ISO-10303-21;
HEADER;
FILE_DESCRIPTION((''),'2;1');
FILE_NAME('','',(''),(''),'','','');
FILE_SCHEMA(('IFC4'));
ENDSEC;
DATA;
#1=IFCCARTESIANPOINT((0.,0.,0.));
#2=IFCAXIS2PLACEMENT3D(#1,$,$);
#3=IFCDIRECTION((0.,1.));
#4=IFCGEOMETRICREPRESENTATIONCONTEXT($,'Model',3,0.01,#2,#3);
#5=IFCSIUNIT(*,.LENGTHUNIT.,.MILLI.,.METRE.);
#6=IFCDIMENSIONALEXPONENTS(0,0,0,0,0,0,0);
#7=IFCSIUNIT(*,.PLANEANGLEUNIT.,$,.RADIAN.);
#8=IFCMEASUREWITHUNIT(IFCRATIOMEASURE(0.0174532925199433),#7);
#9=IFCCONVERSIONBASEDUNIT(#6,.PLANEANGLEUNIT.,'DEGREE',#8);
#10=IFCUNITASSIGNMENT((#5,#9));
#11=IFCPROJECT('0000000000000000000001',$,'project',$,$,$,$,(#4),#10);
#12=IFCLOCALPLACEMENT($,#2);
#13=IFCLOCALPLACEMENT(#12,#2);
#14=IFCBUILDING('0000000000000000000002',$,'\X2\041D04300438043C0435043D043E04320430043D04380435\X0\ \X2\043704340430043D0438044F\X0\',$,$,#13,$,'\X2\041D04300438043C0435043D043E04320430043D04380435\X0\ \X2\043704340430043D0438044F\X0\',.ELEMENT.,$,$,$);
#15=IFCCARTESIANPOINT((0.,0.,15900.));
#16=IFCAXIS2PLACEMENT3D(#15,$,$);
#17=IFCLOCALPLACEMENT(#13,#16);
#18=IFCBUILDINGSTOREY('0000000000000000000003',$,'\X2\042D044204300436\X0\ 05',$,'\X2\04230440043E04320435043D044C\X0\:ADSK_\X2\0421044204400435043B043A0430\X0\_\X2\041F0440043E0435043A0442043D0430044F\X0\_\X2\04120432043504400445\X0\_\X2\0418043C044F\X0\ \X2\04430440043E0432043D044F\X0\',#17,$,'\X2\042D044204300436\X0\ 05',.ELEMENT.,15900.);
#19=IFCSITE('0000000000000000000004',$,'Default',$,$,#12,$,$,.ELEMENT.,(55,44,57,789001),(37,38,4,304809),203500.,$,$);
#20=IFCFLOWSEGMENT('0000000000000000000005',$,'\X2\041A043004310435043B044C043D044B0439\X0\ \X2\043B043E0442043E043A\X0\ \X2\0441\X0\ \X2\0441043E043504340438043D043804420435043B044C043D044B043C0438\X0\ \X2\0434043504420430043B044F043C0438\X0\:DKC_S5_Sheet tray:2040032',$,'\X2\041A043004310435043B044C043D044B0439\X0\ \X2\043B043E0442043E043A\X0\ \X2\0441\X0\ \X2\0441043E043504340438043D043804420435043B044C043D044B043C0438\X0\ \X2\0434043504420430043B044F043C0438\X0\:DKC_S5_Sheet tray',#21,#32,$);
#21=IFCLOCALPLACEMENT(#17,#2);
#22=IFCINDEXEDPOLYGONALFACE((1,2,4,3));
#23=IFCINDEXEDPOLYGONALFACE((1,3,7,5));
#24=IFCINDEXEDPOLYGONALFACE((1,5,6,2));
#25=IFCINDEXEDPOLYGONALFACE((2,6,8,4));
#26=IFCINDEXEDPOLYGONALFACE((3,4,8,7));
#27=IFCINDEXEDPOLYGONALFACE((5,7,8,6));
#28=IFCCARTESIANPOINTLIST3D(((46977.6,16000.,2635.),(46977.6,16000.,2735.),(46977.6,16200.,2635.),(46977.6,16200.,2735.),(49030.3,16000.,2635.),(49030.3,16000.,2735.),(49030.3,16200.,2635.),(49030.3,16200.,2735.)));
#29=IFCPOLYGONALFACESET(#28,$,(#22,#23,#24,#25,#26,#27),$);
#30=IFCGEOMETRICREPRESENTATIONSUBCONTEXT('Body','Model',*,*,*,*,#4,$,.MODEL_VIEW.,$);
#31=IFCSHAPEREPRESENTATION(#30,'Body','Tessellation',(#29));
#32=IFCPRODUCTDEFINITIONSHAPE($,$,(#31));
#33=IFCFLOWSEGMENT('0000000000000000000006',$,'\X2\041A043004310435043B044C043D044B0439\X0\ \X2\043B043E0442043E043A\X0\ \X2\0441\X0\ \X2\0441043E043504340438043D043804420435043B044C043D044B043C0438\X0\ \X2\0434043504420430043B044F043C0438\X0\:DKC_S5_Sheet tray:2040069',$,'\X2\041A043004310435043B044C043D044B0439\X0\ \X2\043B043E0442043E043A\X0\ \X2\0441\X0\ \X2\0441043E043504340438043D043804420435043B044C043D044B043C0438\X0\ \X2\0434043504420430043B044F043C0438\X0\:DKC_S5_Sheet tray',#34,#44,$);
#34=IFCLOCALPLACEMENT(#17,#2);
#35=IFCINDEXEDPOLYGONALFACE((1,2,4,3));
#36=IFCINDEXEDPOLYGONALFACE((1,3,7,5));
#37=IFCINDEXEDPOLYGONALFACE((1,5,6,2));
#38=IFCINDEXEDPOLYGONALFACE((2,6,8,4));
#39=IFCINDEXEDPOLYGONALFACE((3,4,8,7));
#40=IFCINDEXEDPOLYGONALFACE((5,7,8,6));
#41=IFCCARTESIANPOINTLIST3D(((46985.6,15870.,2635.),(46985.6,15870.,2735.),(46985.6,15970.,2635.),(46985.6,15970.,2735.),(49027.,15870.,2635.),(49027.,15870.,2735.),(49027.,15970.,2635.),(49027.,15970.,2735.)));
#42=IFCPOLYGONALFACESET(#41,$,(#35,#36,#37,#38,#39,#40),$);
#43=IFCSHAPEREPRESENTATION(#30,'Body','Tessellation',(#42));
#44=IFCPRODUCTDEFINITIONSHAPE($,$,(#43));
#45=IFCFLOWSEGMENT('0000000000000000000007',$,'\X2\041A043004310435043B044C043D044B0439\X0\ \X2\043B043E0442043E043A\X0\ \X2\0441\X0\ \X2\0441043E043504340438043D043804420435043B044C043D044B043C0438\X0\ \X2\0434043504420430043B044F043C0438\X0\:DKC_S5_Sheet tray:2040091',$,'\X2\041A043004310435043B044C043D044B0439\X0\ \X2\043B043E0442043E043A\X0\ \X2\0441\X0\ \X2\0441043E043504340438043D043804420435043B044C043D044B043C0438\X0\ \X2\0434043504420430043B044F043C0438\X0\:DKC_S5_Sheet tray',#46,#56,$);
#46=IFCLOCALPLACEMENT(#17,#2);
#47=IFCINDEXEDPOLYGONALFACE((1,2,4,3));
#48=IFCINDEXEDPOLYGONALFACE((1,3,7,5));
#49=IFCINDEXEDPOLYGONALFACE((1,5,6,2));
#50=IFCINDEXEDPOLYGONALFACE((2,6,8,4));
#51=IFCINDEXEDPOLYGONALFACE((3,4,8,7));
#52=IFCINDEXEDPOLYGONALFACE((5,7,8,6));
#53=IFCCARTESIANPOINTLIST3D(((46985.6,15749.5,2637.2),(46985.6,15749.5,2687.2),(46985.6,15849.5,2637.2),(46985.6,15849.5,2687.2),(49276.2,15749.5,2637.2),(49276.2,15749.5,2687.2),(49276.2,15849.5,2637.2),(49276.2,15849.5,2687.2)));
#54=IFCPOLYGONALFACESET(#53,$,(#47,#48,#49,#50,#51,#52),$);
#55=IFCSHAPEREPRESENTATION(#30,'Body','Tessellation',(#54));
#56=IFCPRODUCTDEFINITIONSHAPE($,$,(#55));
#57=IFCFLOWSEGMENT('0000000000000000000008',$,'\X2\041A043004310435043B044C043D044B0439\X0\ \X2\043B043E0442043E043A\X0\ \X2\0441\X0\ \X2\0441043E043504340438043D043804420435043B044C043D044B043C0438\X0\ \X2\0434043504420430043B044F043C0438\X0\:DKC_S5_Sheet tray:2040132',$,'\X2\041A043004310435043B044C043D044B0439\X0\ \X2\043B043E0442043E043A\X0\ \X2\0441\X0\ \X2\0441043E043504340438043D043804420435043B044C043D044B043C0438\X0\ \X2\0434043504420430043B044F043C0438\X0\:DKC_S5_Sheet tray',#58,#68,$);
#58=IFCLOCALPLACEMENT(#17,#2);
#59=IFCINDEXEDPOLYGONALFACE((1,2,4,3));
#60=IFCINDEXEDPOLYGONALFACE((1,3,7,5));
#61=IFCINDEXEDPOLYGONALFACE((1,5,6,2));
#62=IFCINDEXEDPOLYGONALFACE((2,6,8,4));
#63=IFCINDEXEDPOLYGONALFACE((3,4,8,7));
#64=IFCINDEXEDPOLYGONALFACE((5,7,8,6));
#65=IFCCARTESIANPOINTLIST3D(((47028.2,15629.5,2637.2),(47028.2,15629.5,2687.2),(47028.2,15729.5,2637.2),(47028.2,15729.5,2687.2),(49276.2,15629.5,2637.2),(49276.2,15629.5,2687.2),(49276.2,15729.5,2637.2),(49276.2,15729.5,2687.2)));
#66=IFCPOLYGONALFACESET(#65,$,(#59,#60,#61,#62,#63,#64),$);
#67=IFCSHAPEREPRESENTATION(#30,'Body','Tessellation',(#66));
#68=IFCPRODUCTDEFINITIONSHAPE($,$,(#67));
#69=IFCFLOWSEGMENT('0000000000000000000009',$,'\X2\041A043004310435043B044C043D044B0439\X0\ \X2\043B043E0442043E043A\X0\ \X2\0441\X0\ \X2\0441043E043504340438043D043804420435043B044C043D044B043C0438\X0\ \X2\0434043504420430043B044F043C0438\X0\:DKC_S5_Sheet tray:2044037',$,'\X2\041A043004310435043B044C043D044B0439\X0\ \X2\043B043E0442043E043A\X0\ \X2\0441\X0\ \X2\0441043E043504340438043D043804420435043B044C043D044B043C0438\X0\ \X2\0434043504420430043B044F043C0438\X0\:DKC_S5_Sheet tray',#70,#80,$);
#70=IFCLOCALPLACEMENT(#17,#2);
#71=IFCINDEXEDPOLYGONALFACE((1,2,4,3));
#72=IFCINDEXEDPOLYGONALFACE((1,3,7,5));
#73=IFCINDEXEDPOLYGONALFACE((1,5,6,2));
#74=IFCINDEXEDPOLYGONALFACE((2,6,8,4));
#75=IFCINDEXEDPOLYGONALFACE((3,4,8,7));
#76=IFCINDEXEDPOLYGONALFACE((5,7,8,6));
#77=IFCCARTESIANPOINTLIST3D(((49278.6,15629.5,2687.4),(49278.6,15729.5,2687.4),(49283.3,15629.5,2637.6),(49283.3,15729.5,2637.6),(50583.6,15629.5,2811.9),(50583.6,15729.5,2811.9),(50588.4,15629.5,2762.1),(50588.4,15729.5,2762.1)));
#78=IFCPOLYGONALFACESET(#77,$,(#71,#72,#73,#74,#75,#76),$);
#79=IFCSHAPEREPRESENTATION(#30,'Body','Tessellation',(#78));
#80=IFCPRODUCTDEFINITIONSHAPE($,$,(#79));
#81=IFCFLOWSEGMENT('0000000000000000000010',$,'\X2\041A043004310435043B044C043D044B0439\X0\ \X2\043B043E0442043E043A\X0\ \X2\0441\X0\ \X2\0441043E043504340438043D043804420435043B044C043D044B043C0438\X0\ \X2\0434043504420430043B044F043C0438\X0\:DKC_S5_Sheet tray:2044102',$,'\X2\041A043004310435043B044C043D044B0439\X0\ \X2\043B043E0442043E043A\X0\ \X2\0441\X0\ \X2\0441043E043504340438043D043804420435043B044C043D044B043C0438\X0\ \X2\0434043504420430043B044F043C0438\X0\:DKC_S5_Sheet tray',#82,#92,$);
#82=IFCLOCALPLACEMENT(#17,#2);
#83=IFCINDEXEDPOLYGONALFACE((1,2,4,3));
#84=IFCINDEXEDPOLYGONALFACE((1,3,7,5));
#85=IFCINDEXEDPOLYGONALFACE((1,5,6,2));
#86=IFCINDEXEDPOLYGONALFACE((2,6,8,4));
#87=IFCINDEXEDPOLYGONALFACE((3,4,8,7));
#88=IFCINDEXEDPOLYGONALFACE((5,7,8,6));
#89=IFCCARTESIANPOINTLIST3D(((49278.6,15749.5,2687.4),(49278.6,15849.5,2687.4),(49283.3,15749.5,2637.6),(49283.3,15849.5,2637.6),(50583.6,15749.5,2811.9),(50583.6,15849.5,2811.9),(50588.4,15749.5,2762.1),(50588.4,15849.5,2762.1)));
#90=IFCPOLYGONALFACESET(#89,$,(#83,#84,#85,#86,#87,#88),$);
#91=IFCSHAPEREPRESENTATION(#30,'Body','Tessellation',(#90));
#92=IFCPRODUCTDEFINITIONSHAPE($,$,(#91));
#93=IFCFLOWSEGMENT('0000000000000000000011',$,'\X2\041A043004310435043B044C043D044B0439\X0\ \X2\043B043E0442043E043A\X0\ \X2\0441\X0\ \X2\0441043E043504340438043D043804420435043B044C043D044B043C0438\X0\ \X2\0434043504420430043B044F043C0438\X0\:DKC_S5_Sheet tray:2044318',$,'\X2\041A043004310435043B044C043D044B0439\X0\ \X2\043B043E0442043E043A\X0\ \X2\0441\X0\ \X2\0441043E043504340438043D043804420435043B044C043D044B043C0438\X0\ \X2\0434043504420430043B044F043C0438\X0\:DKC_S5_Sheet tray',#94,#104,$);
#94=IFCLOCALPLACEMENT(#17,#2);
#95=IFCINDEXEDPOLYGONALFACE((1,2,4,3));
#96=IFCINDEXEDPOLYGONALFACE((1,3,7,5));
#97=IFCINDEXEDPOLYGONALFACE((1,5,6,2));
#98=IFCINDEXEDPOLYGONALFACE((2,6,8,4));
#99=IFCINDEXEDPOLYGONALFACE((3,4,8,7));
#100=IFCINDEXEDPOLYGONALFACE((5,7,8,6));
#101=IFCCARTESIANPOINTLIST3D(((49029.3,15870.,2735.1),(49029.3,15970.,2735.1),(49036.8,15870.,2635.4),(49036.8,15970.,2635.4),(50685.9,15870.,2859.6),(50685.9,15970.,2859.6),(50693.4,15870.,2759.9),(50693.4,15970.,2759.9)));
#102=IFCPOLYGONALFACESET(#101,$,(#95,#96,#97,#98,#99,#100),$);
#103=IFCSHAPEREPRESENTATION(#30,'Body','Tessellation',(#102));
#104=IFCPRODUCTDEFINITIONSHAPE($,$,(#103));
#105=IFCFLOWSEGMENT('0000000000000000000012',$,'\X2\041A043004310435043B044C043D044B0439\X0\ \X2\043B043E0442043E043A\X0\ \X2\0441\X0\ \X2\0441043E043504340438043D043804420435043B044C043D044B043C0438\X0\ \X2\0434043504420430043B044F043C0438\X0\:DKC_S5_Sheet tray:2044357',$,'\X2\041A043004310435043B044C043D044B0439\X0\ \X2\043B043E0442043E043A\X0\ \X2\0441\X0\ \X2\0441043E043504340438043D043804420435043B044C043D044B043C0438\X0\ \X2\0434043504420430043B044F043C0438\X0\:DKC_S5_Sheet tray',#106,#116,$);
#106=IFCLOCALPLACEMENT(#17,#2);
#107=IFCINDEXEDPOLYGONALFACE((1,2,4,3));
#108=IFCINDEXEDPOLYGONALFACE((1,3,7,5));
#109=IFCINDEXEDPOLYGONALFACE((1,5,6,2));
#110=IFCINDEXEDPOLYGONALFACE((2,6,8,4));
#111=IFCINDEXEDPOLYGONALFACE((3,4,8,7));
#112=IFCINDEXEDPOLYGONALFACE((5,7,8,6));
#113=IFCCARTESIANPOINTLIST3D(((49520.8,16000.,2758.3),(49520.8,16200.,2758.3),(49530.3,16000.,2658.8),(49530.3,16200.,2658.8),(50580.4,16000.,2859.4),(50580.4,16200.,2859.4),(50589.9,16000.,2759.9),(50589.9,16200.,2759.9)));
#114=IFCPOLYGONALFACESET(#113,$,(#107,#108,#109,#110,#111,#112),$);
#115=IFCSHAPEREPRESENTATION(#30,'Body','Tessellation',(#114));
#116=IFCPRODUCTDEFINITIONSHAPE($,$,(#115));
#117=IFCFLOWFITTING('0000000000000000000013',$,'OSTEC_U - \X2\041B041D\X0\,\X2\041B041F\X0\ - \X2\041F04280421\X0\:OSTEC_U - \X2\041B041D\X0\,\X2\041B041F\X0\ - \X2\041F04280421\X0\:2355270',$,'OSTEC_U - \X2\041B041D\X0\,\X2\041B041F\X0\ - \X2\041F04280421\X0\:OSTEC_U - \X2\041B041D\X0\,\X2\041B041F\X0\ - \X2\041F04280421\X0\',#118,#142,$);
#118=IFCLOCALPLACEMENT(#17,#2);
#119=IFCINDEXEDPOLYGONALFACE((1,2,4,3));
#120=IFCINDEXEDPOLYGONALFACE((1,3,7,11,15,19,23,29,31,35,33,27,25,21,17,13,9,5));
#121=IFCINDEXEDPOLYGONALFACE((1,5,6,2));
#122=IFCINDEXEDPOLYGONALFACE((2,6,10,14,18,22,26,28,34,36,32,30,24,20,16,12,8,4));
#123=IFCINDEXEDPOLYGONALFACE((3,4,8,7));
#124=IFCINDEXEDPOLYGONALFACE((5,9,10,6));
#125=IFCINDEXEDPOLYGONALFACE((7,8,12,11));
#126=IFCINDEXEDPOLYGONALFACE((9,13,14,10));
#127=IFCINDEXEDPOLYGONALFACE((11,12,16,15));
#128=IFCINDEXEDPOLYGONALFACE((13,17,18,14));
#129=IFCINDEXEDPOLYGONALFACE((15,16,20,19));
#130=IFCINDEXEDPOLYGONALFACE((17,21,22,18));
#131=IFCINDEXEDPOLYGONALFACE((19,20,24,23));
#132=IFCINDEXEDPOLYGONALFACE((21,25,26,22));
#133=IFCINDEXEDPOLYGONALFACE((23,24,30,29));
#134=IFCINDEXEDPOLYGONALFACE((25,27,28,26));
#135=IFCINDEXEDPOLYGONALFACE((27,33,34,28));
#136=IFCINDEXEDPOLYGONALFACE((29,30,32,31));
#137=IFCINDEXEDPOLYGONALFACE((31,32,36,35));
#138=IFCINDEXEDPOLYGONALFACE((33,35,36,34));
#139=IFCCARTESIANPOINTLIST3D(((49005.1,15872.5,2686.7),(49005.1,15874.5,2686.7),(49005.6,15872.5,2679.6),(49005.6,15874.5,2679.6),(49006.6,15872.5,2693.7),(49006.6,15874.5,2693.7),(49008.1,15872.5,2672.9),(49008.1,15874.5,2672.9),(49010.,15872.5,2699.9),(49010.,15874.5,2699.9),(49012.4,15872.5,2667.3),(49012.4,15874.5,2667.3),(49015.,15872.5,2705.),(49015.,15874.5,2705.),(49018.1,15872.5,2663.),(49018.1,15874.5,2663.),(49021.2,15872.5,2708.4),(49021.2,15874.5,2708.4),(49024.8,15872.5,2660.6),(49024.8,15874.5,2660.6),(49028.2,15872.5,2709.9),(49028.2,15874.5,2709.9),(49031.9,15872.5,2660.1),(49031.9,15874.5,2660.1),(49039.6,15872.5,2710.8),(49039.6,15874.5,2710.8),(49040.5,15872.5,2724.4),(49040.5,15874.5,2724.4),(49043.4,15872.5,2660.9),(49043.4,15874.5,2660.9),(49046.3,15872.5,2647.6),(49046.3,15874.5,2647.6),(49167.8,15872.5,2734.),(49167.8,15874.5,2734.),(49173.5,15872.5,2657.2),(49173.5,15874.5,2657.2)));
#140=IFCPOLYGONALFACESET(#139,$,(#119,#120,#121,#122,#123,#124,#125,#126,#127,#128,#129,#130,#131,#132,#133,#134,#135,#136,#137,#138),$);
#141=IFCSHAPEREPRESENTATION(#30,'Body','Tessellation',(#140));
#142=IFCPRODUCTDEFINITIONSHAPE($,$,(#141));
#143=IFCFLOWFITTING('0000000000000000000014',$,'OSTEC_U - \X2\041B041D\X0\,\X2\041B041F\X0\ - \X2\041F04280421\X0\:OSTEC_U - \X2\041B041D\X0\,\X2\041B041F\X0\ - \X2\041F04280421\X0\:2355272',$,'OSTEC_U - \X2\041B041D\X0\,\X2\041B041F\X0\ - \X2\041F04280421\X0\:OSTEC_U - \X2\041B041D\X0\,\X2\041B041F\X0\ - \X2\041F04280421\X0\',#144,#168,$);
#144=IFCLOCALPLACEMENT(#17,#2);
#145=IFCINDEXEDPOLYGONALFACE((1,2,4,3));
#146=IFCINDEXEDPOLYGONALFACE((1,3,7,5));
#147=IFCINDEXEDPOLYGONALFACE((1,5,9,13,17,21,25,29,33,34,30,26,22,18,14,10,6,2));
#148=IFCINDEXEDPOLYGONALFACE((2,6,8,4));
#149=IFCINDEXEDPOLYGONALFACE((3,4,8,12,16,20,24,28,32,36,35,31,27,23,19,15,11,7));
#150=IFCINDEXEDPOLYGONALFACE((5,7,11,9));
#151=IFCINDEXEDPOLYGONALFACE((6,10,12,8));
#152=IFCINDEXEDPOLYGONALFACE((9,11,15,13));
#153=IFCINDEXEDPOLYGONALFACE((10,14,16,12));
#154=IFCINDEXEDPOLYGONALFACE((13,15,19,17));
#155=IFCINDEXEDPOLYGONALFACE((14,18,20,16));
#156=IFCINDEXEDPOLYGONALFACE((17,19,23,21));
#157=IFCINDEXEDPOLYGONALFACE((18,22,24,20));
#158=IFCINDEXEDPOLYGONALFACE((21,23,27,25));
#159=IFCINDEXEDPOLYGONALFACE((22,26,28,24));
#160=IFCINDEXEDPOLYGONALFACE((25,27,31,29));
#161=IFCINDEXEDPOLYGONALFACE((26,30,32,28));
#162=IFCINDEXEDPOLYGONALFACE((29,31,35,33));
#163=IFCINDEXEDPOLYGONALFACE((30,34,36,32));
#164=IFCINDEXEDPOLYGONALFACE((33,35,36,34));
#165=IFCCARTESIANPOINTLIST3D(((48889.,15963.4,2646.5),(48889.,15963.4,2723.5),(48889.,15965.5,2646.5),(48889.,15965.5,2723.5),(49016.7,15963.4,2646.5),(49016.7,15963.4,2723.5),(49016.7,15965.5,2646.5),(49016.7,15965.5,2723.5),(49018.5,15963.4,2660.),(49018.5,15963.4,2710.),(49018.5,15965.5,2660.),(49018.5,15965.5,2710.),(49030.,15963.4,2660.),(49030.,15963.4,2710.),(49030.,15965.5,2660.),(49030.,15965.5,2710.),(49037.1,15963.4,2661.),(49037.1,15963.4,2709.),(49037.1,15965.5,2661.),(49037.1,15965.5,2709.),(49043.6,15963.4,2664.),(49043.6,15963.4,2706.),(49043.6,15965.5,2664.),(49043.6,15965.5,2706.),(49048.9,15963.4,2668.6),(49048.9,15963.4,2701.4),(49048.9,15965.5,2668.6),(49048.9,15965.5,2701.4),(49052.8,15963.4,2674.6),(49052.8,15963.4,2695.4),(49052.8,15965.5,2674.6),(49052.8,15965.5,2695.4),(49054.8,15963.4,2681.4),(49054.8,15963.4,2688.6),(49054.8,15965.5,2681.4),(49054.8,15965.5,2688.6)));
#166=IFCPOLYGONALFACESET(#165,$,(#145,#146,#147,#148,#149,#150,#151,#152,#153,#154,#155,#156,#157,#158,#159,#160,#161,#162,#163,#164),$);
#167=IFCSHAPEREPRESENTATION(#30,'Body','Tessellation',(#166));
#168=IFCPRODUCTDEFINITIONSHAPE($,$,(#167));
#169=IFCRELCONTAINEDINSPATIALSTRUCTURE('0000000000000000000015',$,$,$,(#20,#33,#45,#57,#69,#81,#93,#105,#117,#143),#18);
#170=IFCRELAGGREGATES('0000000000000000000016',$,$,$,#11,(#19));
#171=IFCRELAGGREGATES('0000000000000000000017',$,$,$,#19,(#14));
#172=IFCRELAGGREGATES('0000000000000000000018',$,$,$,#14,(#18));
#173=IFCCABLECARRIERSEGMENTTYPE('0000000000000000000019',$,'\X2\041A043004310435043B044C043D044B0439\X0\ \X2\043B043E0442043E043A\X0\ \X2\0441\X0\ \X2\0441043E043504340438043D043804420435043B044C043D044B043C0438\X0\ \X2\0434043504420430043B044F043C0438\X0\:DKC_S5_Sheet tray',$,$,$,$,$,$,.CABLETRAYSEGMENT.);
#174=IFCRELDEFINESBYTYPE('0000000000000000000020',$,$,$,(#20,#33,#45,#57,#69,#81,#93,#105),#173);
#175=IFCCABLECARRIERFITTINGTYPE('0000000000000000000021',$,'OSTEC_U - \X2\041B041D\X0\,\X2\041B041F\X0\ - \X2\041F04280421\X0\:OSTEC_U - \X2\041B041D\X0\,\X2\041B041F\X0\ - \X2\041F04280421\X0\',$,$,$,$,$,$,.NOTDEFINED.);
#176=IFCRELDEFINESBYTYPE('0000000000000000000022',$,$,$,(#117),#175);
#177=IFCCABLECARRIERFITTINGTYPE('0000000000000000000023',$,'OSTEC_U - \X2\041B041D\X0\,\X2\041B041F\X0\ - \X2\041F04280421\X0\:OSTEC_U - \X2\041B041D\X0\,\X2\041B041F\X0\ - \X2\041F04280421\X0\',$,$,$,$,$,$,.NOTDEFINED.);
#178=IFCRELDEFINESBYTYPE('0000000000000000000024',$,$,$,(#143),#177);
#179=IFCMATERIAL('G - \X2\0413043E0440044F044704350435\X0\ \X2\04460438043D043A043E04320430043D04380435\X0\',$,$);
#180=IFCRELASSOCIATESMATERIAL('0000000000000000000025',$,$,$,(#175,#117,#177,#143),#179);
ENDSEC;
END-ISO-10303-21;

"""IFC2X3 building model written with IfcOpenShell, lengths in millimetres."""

from ifc_helpers import new_model, entity, si_unit, converted_unit, direction, frame, frame_2d, origin, origin_2d_with_axis, place, context, subcontext, project, spatial, polyline, circle_curve, parameter, trimmed, segment, composite_curve, rectangle, outline, extrude, source, transform, mapped, material, type_object, type_shapes, element, save


model = new_model("IFC2X3")

# Units and contexts
model_context = context("Model", 3, precision=0.01, world=origin(), true_north=direction((0.0, 1.0)))
body_context = subcontext(model_context, "Body", "Model", "MODEL_VIEW")
ifc_project = project(units=[si_unit("LENGTHUNIT", "METRE", prefix="MILLI"), converted_unit("PLANEANGLEUNIT", "DEGREE", entity("IfcRatioMeasure", 0.0174532925199433), si_unit("PLANEANGLEUNIT", "RADIAN"), dimensions=[0, 0, 0, 0, 0, 0, 0])], contexts=[model_context])

# Site, building, storey
site_placement = place(None, origin())
site = spatial("IfcSite", under=ifc_project, at=site_placement, Name="Default", CompositionType="ELEMENT", RefLatitude=(55, 44, 57, 789001), RefLongitude=(37, 38, 4, 304809), RefElevation=203500.0)
building_placement = place(site_placement, origin())
building = spatial("IfcBuilding", under=site, at=building_placement, Name="Наименование здания", LongName="Наименование здания", CompositionType="ELEMENT")
storey_placement = place(building_placement, frame((0.0, 0.0, 15900.0)))
storey = spatial("IfcBuildingStorey", under=building, at=storey_placement, Name="Этаж 05", ObjectType="Уровень:ADSK_Стрелка_Проектная_Вверх_Имя уровня", LongName="Этаж 05", CompositionType="ELEMENT", Elevation=15900.0)

# Flow segments
cable_carrier_segment_type = type_object("IfcCableCarrierSegmentType", Name="Кабельный лоток с соединительными деталями:DKC_S5_Sheet tray", PredefinedType="CABLETRAYSEGMENT")
flow_segment_1_placement = place(storey_placement, frame((46977.6, 16000.0, 2635.0)))
element("IfcFlowSegment", 1, at=flow_segment_1_placement, inside=storey, type_object=cable_carrier_segment_type, Name="Кабельный лоток с соединительными деталями:DKC_S5_Sheet tray:2040032", ObjectType="Кабельный лоток с соединительными деталями:DKC_S5_Sheet tray", context=body_context, shape_type="SweptSolid", body=[
    extrude(rectangle(XDim=2052.8, YDim=200.0, at=origin_2d_with_axis()), frame((1026.4, 100.0, 0.0)), (0.0, 0.0, 1.0), 100.0),
])
flow_segment_2_placement = place(storey_placement, frame((46985.6, 15870.0, 2635.0)))
element("IfcFlowSegment", 2, at=flow_segment_2_placement, inside=storey, type_object=cable_carrier_segment_type, Name="Кабельный лоток с соединительными деталями:DKC_S5_Sheet tray:2040069", ObjectType="Кабельный лоток с соединительными деталями:DKC_S5_Sheet tray", context=body_context, shape_type="SweptSolid", body=[
    extrude(rectangle(XDim=2041.4, YDim=100.0, at=origin_2d_with_axis()), frame((1020.7, 50.0, 0.0)), (0.0, 0.0, 1.0), 100.0),
])
flow_segment_3_placement = place(storey_placement, frame((46985.6, 15749.5, 2637.2)))
element("IfcFlowSegment", 3, at=flow_segment_3_placement, inside=storey, type_object=cable_carrier_segment_type, Name="Кабельный лоток с соединительными деталями:DKC_S5_Sheet tray:2040091", ObjectType="Кабельный лоток с соединительными деталями:DKC_S5_Sheet tray", context=body_context, shape_type="SweptSolid", body=[
    extrude(rectangle(XDim=2290.7, YDim=100.0, at=origin_2d_with_axis()), frame((1145.3, 50.0, 0.0)), (0.0, 0.0, 1.0), 50.0),
])
flow_segment_4_placement = place(storey_placement, frame((47028.2, 15629.5, 2637.2)))
element("IfcFlowSegment", 4, at=flow_segment_4_placement, inside=storey, type_object=cable_carrier_segment_type, Name="Кабельный лоток с соединительными деталями:DKC_S5_Sheet tray:2040132", ObjectType="Кабельный лоток с соединительными деталями:DKC_S5_Sheet tray", context=body_context, shape_type="SweptSolid", body=[
    extrude(rectangle(XDim=2248.0, YDim=100.0, at=origin_2d_with_axis()), frame((1124.0, 50.0, 0.0), z_axis=(0.0, 0.0, 1.0), x_axis=(-1.0, 0.0, 0.0)), (0.0, 0.0, 1.0), 50.0),
])
flow_segment_5_placement = place(storey_placement, frame((49278.6, 15629.5, 2637.6)))
element("IfcFlowSegment", 5, at=flow_segment_5_placement, inside=storey, type_object=cable_carrier_segment_type, Name="Кабельный лоток с соединительными деталями:DKC_S5_Sheet tray:2044037", ObjectType="Кабельный лоток с соединительными деталями:DKC_S5_Sheet tray", context=body_context, shape_type="SweptSolid", body=[
    extrude(rectangle(XDim=50.0, YDim=100.0, at=origin_2d_with_axis()), frame((2.4, 50.0, 24.9), z_axis=(0.99548, 0.0, 0.094972), x_axis=(-0.094972, 0.0, 0.99548)), (0.0, 0.0, 1.0), 1310.9),
])
flow_segment_6_placement = place(storey_placement, frame((49278.6, 15749.5, 2637.6)))
element("IfcFlowSegment", 6, at=flow_segment_6_placement, inside=storey, type_object=cable_carrier_segment_type, Name="Кабельный лоток с соединительными деталями:DKC_S5_Sheet tray:2044102", ObjectType="Кабельный лоток с соединительными деталями:DKC_S5_Sheet tray", context=body_context, shape_type="SweptSolid", body=[
    extrude(rectangle(XDim=50.0, YDim=100.0, at=origin_2d_with_axis()), frame((2.4, 50.0, 24.9), z_axis=(0.99548, 0.0, 0.094972), x_axis=(-0.094972, 0.0, 0.99548)), (0.0, 0.0, 1.0), 1310.9),
])
flow_segment_7_placement = place(storey_placement, frame((49029.3, 15870.0, 2635.4)))
element("IfcFlowSegment", 7, at=flow_segment_7_placement, inside=storey, type_object=cable_carrier_segment_type, Name="Кабельный лоток с соединительными деталями:DKC_S5_Sheet tray:2044318", ObjectType="Кабельный лоток с соединительными деталями:DKC_S5_Sheet tray", context=body_context, shape_type="SweptSolid", body=[
    extrude(rectangle(XDim=100.0, YDim=100.0, at=frame_2d((0.0, 0.0), x_axis=(0.0, 1.0))), frame((3.8, 50.0, 49.9), z_axis=(0.997186, 0.0, 0.074969), x_axis=(0.0, 1.0, 0.0)), (0.0, 0.0, 1.0), 1661.3),
])
flow_segment_8_placement = place(storey_placement, frame((49520.8, 16000.0, 2658.8)))
element("IfcFlowSegment", 8, at=flow_segment_8_placement, inside=storey, type_object=cable_carrier_segment_type, Name="Кабельный лоток с соединительными деталями:DKC_S5_Sheet tray:2044357", ObjectType="Кабельный лоток с соединительными деталями:DKC_S5_Sheet tray", context=body_context, shape_type="SweptSolid", body=[
    extrude(rectangle(XDim=100.0, YDim=200.0, at=origin_2d_with_axis()), frame((4.8, 100.0, 49.8), z_axis=(0.99548, 0.0, 0.094972), x_axis=(-0.094972, 0.0, 0.99548)), (0.0, 0.0, 1.0), 1064.4),
])

# Flow fittings
ifc_material_1 = material(Name="G - Горячее цинкование")
cable_carrier_fitting_type_1 = type_object("IfcCableCarrierFittingType", Name="OSTEC_U - ЛН,ЛП - ПШС:OSTEC_U - ЛН,ЛП - ПШС", PredefinedType="NOTDEFINED", material=ifc_material_1)
shared_shape_1 = source(origin(), body_context, "Body", "SweptSolid", [
    extrude(outline(composite_curve([segment(trimmed(circle_curve(frame_2d((-41.5, 0.0), x_axis=(1.0, 0.0)), 25.0), [parameter(90.0)], [parameter(270.0)], True, "PARAMETER"), True, "CONTINUOUS"), segment(polyline([(-41.5, -25.0), (-30.0, -25.0)]), True, "CONTINUOUS"), segment(polyline([(-30.0, -25.0), (-28.1, -38.5)]), True, "CONTINUOUS"), segment(polyline([(-28.1, -38.5), (99.5, -38.5)]), True, "CONTINUOUS"), segment(polyline([(99.5, -38.5), (99.5, 38.5)]), True, "CONTINUOUS"), segment(polyline([(99.5, 38.5), (-28.1, 38.5)]), True, "CONTINUOUS"), segment(polyline([(-28.1, 38.5), (-30.0, 25.0)]), True, "CONTINUOUS"), segment(polyline([(-30.0, 25.0), (-41.5, 25.0)]), True, "CONTINUOUS")], self_intersect=False)), frame((41.5, 0.0, 0.0), z_axis=(0.0, 0.0, -1.0), x_axis=(1.0, 0.0, 0.0)), (0.0, 0.0, -1.0), 2.0),
])
type_shapes(cable_carrier_fitting_type_1, [shared_shape_1])
flow_fitting_1_placement = place(storey_placement, frame((49030.0, 15874.5, 2685.0), z_axis=(0.0, -1.0, 0.0), x_axis=(0.997186, 0.0, 0.074969)))
element("IfcFlowFitting", 9, at=flow_fitting_1_placement, inside=storey, type_object=cable_carrier_fitting_type_1, material=ifc_material_1, Name="OSTEC_U - ЛН,ЛП - ПШС:OSTEC_U - ЛН,ЛП - ПШС:2355270", ObjectType="OSTEC_U - ЛН,ЛП - ПШС:OSTEC_U - ЛН,ЛП - ПШС", context=body_context, shape_type="MappedRepresentation", body=[
    mapped(shared_shape_1, transform((0.0, 0.0, 0.0), scale=1.0)),
])
cable_carrier_fitting_type_2 = type_object("IfcCableCarrierFittingType", Name="OSTEC_U - ЛН,ЛП - ПШС:OSTEC_U - ЛН,ЛП - ПШС", PredefinedType="NOTDEFINED", material=ifc_material_1)
type_shapes(cable_carrier_fitting_type_2, [shared_shape_1])
flow_fitting_2_placement = place(storey_placement, frame((49030.0, 15963.5, 2685.0), z_axis=(0.0, 1.0, 0.0), x_axis=(-1.0, 0.0, 0.0)))
element("IfcFlowFitting", 10, at=flow_fitting_2_placement, inside=storey, type_object=cable_carrier_fitting_type_2, material=ifc_material_1, Name="OSTEC_U - ЛН,ЛП - ПШС:OSTEC_U - ЛН,ЛП - ПШС:2355272", ObjectType="OSTEC_U - ЛН,ЛП - ПШС:OSTEC_U - ЛН,ЛП - ПШС", context=body_context, shape_type="MappedRepresentation", body=[
    mapped(shared_shape_1, transform((0.0, 0.0, 0.0), scale=1.0)),
])

save(model, "model.ifc")
